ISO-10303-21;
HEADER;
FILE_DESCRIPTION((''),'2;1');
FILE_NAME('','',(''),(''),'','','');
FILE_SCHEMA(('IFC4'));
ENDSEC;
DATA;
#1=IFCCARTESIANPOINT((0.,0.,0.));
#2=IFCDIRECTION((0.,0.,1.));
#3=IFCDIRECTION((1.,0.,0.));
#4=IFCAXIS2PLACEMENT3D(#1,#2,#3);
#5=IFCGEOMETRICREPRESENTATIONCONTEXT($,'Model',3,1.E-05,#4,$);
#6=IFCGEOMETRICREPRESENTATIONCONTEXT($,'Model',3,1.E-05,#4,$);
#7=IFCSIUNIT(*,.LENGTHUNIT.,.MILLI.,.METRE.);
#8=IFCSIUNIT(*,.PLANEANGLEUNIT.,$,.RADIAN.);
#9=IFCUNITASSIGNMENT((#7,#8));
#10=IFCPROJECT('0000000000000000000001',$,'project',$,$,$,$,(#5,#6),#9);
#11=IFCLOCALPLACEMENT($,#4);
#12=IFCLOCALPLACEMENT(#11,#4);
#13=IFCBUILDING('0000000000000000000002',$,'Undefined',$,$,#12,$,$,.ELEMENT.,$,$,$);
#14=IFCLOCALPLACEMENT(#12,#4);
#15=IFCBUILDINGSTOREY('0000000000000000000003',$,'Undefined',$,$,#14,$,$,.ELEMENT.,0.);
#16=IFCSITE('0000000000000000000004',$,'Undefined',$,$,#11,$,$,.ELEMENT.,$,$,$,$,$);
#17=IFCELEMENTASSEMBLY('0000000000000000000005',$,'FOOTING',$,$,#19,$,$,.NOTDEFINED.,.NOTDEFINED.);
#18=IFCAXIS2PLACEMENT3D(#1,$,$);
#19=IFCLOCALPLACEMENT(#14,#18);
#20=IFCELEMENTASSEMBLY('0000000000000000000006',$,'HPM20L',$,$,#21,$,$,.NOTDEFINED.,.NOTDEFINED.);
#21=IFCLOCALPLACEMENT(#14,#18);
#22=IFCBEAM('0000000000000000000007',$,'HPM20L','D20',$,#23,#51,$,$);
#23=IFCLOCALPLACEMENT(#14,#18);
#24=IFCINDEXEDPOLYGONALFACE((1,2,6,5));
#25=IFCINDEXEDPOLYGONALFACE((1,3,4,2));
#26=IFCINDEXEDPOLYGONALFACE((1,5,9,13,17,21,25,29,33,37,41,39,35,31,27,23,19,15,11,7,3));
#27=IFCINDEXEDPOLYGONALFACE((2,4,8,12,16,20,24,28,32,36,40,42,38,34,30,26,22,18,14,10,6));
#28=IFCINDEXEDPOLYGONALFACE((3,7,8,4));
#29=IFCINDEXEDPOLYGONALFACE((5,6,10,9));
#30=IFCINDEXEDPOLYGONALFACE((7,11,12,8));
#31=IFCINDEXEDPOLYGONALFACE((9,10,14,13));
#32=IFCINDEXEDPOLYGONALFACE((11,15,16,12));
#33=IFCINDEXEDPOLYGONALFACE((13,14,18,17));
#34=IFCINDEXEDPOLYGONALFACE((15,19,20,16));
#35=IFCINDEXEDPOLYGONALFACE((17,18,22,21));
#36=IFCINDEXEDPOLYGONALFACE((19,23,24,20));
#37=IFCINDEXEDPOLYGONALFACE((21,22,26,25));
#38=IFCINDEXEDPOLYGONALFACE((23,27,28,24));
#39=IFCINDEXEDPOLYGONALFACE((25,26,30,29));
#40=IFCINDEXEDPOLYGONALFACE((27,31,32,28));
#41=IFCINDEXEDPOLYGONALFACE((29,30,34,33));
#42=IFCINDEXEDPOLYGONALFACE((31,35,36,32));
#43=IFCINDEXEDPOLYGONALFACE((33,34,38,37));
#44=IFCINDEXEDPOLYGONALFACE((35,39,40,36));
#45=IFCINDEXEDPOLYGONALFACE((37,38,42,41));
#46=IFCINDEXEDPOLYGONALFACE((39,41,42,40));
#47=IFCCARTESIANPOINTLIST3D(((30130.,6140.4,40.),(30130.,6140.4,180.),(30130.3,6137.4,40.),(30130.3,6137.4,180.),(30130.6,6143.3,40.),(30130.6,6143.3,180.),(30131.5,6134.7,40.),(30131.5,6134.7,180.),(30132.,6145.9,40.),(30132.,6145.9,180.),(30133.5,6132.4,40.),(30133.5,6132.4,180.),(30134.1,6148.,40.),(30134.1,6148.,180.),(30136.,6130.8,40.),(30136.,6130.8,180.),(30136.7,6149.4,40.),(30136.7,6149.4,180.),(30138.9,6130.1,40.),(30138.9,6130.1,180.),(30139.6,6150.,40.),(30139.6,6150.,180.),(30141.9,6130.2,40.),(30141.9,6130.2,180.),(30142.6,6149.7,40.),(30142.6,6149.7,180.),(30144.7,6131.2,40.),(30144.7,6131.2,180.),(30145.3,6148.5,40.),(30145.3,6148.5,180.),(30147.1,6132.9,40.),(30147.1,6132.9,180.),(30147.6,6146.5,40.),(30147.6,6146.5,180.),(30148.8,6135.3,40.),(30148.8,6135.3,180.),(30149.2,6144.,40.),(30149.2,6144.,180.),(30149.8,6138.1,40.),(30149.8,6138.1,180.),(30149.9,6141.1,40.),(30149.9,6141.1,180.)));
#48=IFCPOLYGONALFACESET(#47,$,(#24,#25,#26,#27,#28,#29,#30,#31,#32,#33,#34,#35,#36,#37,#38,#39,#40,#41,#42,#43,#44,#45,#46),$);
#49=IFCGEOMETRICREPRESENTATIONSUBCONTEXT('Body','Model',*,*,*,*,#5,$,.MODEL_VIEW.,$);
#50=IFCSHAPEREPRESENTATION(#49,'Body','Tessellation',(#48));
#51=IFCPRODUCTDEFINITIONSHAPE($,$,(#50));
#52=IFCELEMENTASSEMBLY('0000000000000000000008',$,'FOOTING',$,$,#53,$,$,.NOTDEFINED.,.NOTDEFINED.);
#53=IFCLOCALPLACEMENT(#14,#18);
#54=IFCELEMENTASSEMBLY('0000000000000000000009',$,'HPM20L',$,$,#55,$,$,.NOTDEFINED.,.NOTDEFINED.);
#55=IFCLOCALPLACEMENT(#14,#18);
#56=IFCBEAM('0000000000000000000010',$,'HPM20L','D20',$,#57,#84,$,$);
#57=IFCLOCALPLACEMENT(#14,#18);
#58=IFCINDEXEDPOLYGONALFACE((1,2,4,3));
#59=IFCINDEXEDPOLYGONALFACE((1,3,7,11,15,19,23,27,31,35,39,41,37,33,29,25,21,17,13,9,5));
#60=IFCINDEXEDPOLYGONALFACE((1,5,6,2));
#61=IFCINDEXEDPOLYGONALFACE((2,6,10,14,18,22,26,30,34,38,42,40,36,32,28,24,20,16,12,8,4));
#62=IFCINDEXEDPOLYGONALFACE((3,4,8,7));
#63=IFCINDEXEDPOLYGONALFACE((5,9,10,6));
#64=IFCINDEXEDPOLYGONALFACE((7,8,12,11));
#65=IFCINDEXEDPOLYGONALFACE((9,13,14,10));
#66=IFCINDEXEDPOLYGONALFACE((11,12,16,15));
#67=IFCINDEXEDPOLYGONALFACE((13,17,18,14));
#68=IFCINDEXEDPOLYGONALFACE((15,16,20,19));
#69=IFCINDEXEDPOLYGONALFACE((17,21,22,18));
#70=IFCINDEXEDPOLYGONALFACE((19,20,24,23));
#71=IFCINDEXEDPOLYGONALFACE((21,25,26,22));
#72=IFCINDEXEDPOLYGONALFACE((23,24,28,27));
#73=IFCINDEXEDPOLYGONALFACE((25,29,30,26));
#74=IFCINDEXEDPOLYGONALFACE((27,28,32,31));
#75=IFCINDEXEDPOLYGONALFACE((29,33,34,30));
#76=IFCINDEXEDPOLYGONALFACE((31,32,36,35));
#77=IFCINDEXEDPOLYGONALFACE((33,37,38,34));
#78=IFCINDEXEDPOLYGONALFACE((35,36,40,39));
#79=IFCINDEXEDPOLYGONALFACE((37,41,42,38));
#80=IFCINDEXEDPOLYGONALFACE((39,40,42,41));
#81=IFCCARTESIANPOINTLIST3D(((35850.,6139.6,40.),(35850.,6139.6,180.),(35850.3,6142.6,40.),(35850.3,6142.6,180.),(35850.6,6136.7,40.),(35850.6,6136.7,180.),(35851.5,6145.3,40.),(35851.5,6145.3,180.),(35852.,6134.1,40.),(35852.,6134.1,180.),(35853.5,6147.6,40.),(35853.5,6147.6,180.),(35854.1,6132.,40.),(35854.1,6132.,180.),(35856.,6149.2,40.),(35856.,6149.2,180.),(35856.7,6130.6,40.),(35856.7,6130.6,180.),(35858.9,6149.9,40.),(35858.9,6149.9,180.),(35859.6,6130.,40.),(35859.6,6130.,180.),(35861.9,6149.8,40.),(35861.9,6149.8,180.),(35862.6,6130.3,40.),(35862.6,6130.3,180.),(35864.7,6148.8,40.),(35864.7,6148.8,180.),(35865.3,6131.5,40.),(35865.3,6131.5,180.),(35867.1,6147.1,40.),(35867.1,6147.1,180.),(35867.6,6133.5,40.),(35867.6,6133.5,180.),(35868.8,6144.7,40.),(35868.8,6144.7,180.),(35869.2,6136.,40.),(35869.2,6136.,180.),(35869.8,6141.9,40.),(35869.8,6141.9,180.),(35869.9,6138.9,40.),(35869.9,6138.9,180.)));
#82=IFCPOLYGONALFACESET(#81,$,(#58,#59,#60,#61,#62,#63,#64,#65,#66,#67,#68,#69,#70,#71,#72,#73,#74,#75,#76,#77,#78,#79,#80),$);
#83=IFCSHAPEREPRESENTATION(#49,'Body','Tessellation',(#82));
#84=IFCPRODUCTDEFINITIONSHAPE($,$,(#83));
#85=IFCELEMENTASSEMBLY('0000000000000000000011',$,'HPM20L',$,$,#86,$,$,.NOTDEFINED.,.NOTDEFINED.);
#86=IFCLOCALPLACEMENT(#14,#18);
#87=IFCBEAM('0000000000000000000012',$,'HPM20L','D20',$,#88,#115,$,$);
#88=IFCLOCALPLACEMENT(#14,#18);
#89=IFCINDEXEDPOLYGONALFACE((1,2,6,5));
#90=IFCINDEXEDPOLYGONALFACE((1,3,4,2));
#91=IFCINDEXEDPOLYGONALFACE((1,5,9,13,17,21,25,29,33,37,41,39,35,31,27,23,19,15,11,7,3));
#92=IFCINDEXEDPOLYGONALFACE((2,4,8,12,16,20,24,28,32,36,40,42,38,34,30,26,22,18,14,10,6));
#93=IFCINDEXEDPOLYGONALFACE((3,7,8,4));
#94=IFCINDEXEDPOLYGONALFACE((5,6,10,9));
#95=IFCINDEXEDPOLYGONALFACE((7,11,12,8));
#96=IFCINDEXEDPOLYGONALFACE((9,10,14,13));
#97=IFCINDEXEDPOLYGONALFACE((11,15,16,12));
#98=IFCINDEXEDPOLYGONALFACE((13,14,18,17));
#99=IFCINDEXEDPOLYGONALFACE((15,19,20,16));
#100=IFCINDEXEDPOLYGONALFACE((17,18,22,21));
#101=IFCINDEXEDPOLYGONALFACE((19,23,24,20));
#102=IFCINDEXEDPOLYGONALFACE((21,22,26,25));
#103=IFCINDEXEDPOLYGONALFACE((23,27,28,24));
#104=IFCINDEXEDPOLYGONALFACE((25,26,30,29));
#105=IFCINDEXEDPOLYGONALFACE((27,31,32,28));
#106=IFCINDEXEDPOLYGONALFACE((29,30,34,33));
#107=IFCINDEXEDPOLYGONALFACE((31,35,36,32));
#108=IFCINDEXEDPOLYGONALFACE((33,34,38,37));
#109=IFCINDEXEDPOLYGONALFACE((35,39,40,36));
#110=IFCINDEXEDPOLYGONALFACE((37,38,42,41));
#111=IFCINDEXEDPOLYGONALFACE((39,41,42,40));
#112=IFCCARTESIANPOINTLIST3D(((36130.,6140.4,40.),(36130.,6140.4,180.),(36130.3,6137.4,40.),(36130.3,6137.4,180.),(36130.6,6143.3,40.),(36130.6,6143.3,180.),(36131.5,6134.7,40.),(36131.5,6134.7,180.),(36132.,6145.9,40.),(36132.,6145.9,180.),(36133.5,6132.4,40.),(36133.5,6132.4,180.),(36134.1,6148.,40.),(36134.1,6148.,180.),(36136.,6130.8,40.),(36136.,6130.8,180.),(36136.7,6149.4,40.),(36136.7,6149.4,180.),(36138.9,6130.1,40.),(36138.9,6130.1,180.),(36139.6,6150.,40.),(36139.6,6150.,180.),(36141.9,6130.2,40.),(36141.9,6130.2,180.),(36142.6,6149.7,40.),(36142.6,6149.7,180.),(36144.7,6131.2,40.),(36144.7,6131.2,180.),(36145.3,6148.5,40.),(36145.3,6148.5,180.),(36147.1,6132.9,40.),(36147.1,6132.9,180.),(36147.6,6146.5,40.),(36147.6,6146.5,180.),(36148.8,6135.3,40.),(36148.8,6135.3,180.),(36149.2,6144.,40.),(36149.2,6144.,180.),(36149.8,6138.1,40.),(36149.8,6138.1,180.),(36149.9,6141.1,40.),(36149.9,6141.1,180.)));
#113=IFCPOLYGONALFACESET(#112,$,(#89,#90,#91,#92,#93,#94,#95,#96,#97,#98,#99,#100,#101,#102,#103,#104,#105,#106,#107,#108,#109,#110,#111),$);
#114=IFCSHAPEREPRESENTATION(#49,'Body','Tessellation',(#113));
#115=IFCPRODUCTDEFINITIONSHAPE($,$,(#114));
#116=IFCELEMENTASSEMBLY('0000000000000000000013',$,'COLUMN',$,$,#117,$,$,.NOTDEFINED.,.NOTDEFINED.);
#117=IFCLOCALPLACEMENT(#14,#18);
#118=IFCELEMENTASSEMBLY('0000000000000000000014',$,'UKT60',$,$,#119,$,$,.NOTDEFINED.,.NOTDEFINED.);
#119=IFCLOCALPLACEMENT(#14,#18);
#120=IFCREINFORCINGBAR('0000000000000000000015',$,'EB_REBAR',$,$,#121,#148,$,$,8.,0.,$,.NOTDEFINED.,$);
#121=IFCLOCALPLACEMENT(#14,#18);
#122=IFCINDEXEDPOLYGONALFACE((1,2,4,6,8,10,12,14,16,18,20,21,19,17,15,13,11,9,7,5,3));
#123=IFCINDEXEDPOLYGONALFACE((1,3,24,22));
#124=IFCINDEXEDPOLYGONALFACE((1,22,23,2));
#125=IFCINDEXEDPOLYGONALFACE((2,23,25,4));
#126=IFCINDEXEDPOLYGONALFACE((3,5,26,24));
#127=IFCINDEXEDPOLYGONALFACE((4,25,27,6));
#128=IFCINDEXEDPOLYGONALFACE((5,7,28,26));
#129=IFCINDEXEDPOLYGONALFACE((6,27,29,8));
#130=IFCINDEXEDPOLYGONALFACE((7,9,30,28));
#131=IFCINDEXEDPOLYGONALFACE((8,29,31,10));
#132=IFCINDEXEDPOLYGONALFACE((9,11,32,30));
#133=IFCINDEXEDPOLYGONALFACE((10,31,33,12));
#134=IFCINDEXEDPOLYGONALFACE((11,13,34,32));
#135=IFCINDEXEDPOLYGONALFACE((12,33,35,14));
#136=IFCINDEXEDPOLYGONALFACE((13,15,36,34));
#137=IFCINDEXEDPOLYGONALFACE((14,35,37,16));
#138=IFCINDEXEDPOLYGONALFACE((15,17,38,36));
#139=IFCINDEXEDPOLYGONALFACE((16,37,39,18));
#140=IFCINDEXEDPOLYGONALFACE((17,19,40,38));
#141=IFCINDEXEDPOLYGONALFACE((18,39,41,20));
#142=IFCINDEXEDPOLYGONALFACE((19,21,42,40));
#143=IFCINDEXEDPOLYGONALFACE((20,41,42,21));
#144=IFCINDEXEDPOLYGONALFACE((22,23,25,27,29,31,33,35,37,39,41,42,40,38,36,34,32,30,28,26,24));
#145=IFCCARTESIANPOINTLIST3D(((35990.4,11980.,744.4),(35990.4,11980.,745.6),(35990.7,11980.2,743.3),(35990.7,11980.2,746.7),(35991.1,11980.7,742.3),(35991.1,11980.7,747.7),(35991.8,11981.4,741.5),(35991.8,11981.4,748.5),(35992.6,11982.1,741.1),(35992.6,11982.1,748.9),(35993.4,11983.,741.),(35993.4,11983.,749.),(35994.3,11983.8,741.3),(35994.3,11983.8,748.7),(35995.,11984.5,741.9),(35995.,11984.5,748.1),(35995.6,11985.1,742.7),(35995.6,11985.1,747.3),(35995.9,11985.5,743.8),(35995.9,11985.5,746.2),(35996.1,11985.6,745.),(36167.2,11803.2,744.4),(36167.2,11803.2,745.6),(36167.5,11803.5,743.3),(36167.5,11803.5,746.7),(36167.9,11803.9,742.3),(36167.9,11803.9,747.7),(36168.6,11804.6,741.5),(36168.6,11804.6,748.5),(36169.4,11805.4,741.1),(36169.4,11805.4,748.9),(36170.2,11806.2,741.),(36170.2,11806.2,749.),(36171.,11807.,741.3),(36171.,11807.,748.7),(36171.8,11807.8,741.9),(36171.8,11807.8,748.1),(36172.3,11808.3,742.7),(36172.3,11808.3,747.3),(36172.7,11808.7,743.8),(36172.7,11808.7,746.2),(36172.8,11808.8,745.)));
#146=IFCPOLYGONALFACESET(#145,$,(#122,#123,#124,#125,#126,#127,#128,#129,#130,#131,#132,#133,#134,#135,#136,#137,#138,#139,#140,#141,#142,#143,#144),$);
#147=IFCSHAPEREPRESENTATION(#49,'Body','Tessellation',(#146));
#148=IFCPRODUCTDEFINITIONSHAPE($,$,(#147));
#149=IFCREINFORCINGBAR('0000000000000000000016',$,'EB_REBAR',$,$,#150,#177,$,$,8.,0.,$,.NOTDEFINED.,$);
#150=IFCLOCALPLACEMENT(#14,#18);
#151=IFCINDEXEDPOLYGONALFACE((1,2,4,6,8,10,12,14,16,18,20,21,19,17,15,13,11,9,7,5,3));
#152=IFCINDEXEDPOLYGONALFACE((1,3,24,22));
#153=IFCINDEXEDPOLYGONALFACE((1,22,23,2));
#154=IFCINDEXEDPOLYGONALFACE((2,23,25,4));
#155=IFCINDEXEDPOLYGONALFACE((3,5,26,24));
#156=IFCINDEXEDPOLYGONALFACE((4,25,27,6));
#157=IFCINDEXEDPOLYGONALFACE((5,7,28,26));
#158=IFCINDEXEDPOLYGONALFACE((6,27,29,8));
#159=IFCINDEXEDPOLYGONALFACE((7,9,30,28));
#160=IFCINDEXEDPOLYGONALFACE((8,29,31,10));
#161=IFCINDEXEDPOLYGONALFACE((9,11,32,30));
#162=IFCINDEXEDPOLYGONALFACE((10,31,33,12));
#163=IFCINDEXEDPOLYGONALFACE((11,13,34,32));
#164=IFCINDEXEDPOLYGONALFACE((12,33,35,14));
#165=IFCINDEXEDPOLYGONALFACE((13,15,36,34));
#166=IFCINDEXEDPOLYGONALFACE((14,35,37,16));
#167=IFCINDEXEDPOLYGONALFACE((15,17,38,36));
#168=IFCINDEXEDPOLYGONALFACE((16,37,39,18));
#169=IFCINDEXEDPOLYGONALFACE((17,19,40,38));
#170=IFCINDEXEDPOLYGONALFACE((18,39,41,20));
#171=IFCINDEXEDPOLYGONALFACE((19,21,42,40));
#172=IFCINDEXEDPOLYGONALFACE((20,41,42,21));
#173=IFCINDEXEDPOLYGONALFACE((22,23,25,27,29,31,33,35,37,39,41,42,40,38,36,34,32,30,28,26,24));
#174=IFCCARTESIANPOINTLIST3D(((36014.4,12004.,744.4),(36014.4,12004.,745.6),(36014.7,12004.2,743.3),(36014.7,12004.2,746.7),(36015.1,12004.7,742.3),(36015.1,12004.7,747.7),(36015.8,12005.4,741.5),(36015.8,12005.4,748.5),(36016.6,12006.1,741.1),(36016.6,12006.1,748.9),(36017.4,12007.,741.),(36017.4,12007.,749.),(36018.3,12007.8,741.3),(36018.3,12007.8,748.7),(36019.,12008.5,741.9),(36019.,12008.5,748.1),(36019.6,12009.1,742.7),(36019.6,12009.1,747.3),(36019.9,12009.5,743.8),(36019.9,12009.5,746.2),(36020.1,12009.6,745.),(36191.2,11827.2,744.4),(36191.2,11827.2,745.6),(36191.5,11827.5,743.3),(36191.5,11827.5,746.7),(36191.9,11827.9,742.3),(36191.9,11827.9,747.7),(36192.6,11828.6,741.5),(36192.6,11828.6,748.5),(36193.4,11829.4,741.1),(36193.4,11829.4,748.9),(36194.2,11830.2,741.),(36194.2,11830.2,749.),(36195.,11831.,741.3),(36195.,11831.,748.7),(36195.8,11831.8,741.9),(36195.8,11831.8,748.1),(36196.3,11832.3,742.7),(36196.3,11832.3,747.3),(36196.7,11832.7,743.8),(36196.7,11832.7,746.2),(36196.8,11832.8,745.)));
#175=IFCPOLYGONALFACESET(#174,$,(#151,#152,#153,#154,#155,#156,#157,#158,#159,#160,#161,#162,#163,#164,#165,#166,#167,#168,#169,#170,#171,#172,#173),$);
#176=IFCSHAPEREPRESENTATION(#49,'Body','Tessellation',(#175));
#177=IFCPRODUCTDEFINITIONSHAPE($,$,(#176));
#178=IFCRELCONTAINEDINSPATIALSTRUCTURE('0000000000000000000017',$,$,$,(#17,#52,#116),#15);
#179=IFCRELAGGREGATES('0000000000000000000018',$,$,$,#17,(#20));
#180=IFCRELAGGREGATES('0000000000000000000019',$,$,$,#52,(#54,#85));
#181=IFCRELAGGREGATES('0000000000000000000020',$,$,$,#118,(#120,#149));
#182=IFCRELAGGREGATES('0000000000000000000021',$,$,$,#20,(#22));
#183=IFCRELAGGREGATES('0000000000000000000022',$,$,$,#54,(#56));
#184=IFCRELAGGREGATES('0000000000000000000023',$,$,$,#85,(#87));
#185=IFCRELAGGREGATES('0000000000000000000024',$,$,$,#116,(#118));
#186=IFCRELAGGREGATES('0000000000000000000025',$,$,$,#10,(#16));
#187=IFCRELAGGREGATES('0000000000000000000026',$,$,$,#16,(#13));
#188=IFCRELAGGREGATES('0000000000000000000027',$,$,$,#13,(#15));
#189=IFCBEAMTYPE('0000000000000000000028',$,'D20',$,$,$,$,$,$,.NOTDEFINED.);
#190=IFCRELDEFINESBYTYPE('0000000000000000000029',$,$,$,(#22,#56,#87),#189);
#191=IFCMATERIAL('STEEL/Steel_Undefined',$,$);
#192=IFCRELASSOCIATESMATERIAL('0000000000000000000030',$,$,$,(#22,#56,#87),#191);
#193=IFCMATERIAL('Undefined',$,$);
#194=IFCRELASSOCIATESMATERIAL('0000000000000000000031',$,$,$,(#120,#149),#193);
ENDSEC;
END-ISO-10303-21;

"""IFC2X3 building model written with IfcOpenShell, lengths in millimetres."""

from ifc_helpers import new_model, entity, si_unit, frame, origin_with_axes, origin_2d_with_axis, place, context, subcontext, project, spatial, circle, extrude, source, transform, mapped, material, type_object, element, aggregate, save


model = new_model("IFC2X3")

# Units and contexts
model_context_1 = context("Model", 3, precision=1e-05, world=origin_with_axes())
model_context_2 = context("Model", 3, precision=1e-05, world=origin_with_axes())
body_context = subcontext(model_context_1, "Body", "Model", "MODEL_VIEW")
ifc_project = project(units=[si_unit("LENGTHUNIT", "METRE", prefix="MILLI"), si_unit("PLANEANGLEUNIT", "RADIAN")], contexts=[model_context_1, model_context_2])

# Site, building, storey
site_placement = place(None, origin_with_axes())
site = spatial("IfcSite", under=ifc_project, at=site_placement, Name="Undefined", CompositionType="ELEMENT")
building_placement = place(site_placement, origin_with_axes())
building = spatial("IfcBuilding", under=site, at=building_placement, Name="Undefined", CompositionType="ELEMENT")
storey_placement = place(building_placement, origin_with_axes())
storey = spatial("IfcBuildingStorey", under=building, at=storey_placement, Name="Undefined", CompositionType="ELEMENT", Elevation=0.0)

# Shared definitions
ifc_material_1 = material(Name="STEEL/Steel_Undefined")
beam_type = type_object("IfcBeamType", Name="D20", PredefinedType="NOTDEFINED")

# Element assemblies, beam
assembly_1_placement = place(storey_placement, origin_with_axes())
assembly_1 = element("IfcElementAssembly", 1, at=assembly_1_placement, inside=storey, Name="FOOTING", AssemblyPlace="NOTDEFINED", PredefinedType="NOTDEFINED")
assembly_2_placement = place(assembly_1_placement, origin_with_axes())
assembly_2 = element("IfcElementAssembly", 2, at=assembly_2_placement, Name="HPM20L", AssemblyPlace="NOTDEFINED", PredefinedType="NOTDEFINED")
aggregate(assembly_1, [assembly_2])
beam_1_placement = place(assembly_2_placement, frame((30140.0, 6140.0, 180.0), z_axis=(0.707107, 0.707107, 0.0), x_axis=(0.0, 0.0, -1.0)))
beam_1 = element("IfcBeam", 3, at=beam_1_placement, type_object=beam_type, material=ifc_material_1, Name="HPM20L", Description="D20", context=body_context, shape_type="SweptSolid", body=[
    extrude(circle(Radius=10.0, at=origin_2d_with_axis()), frame((140.0, 0.0, 0.0), z_axis=(-1.0, 0.0, 0.0), x_axis=(0.0, -1.0, 0.0)), (0.0, 0.0, 1.0), 140.0),
])

# Element assemblies, beams
assembly_3_placement = place(storey_placement, origin_with_axes())
assembly_3 = element("IfcElementAssembly", 4, at=assembly_3_placement, inside=storey, Name="FOOTING", AssemblyPlace="NOTDEFINED", PredefinedType="NOTDEFINED")
assembly_4_placement = place(assembly_3_placement, origin_with_axes())
assembly_4 = element("IfcElementAssembly", 5, at=assembly_4_placement, Name="HPM20L", AssemblyPlace="NOTDEFINED", PredefinedType="NOTDEFINED")
beam_2_placement = place(assembly_4_placement, frame((35860.0, 6140.0, 180.0), z_axis=(-0.707107, 0.707107, 0.0), x_axis=(0.0, 0.0, -1.0)))
beam_2 = element("IfcBeam", 6, at=beam_2_placement, type_object=beam_type, material=ifc_material_1, Name="HPM20L", Description="D20", context=body_context, shape_type="SweptSolid", body=[
    extrude(circle(Radius=10.0, at=origin_2d_with_axis()), frame((140.0, 0.0, 0.0), z_axis=(-1.0, 0.0, 0.0), x_axis=(0.0, -1.0, 0.0)), (0.0, 0.0, 1.0), 140.0),
])
assembly_5_placement = place(assembly_3_placement, origin_with_axes())
assembly_5 = element("IfcElementAssembly", 7, at=assembly_5_placement, Name="HPM20L", AssemblyPlace="NOTDEFINED", PredefinedType="NOTDEFINED")
aggregate(assembly_3, [assembly_4, assembly_5])
beam_3_placement = place(assembly_5_placement, frame((36140.0, 6140.0, 180.0), z_axis=(0.707107, 0.707107, 0.0), x_axis=(0.0, 0.0, -1.0)))
beam_3 = element("IfcBeam", 8, at=beam_3_placement, type_object=beam_type, material=ifc_material_1, Name="HPM20L", Description="D20", context=body_context, shape_type="SweptSolid", body=[
    extrude(circle(Radius=10.0, at=origin_2d_with_axis()), frame((140.0, 0.0, 0.0), z_axis=(-1.0, 0.0, 0.0), x_axis=(0.0, -1.0, 0.0)), (0.0, 0.0, 1.0), 140.0),
])

# Element assemblies, reinforcing bars
assembly_6_placement = place(storey_placement, origin_with_axes())
assembly_6 = element("IfcElementAssembly", 9, at=assembly_6_placement, inside=storey, Name="COLUMN", AssemblyPlace="NOTDEFINED", PredefinedType="NOTDEFINED")
assembly_7_placement = place(assembly_6_placement, origin_with_axes())
assembly_7 = element("IfcElementAssembly", 10, at=assembly_7_placement, Name="UKT60", AssemblyPlace="NOTDEFINED", PredefinedType="NOTDEFINED")
ifc_material_2 = material(Name="Undefined")
shared_shape_1 = source(origin_with_axes(), body_context, "Body", "AdvancedSweptSolid", [
    entity("IfcSweptDiskSolid", entity("IfcTrimmedCurve", entity("IfcLine", entity("IfcCartesianPoint", [0.0, 0.0, 0.0]), entity("IfcVector", entity("IfcDirection", [1.0, 0.0, 0.0]), 1.0)), [entity("IfcParameterValue", 0.0)], [entity("IfcParameterValue", 250.0)], True, "PARAMETER"), 4.0, None, 0.0, 250.0),
])
reinforcing_bar_1_placement = place(assembly_7_placement, frame((36170.0, 11806.0, 745.0), z_axis=(0.707107, 0.707107, 0.0), x_axis=(-0.707107, 0.707107, 0.0)))
reinforcing_bar_1 = element("IfcReinforcingBar", 11, at=reinforcing_bar_1_placement, material=ifc_material_2, Name="EB_REBAR", BarRole="NOTDEFINED", CrossSectionArea=0.0, NominalDiameter=8.0, context=body_context, shape_type="MappedRepresentation", body=[
    mapped(shared_shape_1, transform((0.0, 0.0, 0.0))),
])
shared_shape_2 = source(origin_with_axes(), body_context, "Body", "AdvancedSweptSolid", [
    entity("IfcSweptDiskSolid", entity("IfcTrimmedCurve", entity("IfcLine", entity("IfcCartesianPoint", [0.0, 0.0, 0.0]), entity("IfcVector", entity("IfcDirection", [1.0, 0.0, 0.0]), 1.0)), [entity("IfcParameterValue", 0.0)], [entity("IfcParameterValue", 250.0)], True, "PARAMETER"), 4.0, None, 0.0, 250.0),
])
reinforcing_bar_2_placement = place(assembly_7_placement, frame((36194.0, 11830.0, 745.0), z_axis=(0.707107, 0.707107, 0.0), x_axis=(-0.707107, 0.707107, 0.0)))
reinforcing_bar_2 = element("IfcReinforcingBar", 12, at=reinforcing_bar_2_placement, material=ifc_material_2, Name="EB_REBAR", BarRole="NOTDEFINED", CrossSectionArea=0.0, NominalDiameter=8.0, context=body_context, shape_type="MappedRepresentation", body=[
    mapped(shared_shape_2, transform((0.0, 0.0, 0.0))),
])
aggregate(assembly_7, [reinforcing_bar_1, reinforcing_bar_2])

aggregate(assembly_2, [beam_1])
aggregate(assembly_4, [beam_2])
aggregate(assembly_5, [beam_3])
aggregate(assembly_6, [assembly_7])

save(model, "model.ifc")
